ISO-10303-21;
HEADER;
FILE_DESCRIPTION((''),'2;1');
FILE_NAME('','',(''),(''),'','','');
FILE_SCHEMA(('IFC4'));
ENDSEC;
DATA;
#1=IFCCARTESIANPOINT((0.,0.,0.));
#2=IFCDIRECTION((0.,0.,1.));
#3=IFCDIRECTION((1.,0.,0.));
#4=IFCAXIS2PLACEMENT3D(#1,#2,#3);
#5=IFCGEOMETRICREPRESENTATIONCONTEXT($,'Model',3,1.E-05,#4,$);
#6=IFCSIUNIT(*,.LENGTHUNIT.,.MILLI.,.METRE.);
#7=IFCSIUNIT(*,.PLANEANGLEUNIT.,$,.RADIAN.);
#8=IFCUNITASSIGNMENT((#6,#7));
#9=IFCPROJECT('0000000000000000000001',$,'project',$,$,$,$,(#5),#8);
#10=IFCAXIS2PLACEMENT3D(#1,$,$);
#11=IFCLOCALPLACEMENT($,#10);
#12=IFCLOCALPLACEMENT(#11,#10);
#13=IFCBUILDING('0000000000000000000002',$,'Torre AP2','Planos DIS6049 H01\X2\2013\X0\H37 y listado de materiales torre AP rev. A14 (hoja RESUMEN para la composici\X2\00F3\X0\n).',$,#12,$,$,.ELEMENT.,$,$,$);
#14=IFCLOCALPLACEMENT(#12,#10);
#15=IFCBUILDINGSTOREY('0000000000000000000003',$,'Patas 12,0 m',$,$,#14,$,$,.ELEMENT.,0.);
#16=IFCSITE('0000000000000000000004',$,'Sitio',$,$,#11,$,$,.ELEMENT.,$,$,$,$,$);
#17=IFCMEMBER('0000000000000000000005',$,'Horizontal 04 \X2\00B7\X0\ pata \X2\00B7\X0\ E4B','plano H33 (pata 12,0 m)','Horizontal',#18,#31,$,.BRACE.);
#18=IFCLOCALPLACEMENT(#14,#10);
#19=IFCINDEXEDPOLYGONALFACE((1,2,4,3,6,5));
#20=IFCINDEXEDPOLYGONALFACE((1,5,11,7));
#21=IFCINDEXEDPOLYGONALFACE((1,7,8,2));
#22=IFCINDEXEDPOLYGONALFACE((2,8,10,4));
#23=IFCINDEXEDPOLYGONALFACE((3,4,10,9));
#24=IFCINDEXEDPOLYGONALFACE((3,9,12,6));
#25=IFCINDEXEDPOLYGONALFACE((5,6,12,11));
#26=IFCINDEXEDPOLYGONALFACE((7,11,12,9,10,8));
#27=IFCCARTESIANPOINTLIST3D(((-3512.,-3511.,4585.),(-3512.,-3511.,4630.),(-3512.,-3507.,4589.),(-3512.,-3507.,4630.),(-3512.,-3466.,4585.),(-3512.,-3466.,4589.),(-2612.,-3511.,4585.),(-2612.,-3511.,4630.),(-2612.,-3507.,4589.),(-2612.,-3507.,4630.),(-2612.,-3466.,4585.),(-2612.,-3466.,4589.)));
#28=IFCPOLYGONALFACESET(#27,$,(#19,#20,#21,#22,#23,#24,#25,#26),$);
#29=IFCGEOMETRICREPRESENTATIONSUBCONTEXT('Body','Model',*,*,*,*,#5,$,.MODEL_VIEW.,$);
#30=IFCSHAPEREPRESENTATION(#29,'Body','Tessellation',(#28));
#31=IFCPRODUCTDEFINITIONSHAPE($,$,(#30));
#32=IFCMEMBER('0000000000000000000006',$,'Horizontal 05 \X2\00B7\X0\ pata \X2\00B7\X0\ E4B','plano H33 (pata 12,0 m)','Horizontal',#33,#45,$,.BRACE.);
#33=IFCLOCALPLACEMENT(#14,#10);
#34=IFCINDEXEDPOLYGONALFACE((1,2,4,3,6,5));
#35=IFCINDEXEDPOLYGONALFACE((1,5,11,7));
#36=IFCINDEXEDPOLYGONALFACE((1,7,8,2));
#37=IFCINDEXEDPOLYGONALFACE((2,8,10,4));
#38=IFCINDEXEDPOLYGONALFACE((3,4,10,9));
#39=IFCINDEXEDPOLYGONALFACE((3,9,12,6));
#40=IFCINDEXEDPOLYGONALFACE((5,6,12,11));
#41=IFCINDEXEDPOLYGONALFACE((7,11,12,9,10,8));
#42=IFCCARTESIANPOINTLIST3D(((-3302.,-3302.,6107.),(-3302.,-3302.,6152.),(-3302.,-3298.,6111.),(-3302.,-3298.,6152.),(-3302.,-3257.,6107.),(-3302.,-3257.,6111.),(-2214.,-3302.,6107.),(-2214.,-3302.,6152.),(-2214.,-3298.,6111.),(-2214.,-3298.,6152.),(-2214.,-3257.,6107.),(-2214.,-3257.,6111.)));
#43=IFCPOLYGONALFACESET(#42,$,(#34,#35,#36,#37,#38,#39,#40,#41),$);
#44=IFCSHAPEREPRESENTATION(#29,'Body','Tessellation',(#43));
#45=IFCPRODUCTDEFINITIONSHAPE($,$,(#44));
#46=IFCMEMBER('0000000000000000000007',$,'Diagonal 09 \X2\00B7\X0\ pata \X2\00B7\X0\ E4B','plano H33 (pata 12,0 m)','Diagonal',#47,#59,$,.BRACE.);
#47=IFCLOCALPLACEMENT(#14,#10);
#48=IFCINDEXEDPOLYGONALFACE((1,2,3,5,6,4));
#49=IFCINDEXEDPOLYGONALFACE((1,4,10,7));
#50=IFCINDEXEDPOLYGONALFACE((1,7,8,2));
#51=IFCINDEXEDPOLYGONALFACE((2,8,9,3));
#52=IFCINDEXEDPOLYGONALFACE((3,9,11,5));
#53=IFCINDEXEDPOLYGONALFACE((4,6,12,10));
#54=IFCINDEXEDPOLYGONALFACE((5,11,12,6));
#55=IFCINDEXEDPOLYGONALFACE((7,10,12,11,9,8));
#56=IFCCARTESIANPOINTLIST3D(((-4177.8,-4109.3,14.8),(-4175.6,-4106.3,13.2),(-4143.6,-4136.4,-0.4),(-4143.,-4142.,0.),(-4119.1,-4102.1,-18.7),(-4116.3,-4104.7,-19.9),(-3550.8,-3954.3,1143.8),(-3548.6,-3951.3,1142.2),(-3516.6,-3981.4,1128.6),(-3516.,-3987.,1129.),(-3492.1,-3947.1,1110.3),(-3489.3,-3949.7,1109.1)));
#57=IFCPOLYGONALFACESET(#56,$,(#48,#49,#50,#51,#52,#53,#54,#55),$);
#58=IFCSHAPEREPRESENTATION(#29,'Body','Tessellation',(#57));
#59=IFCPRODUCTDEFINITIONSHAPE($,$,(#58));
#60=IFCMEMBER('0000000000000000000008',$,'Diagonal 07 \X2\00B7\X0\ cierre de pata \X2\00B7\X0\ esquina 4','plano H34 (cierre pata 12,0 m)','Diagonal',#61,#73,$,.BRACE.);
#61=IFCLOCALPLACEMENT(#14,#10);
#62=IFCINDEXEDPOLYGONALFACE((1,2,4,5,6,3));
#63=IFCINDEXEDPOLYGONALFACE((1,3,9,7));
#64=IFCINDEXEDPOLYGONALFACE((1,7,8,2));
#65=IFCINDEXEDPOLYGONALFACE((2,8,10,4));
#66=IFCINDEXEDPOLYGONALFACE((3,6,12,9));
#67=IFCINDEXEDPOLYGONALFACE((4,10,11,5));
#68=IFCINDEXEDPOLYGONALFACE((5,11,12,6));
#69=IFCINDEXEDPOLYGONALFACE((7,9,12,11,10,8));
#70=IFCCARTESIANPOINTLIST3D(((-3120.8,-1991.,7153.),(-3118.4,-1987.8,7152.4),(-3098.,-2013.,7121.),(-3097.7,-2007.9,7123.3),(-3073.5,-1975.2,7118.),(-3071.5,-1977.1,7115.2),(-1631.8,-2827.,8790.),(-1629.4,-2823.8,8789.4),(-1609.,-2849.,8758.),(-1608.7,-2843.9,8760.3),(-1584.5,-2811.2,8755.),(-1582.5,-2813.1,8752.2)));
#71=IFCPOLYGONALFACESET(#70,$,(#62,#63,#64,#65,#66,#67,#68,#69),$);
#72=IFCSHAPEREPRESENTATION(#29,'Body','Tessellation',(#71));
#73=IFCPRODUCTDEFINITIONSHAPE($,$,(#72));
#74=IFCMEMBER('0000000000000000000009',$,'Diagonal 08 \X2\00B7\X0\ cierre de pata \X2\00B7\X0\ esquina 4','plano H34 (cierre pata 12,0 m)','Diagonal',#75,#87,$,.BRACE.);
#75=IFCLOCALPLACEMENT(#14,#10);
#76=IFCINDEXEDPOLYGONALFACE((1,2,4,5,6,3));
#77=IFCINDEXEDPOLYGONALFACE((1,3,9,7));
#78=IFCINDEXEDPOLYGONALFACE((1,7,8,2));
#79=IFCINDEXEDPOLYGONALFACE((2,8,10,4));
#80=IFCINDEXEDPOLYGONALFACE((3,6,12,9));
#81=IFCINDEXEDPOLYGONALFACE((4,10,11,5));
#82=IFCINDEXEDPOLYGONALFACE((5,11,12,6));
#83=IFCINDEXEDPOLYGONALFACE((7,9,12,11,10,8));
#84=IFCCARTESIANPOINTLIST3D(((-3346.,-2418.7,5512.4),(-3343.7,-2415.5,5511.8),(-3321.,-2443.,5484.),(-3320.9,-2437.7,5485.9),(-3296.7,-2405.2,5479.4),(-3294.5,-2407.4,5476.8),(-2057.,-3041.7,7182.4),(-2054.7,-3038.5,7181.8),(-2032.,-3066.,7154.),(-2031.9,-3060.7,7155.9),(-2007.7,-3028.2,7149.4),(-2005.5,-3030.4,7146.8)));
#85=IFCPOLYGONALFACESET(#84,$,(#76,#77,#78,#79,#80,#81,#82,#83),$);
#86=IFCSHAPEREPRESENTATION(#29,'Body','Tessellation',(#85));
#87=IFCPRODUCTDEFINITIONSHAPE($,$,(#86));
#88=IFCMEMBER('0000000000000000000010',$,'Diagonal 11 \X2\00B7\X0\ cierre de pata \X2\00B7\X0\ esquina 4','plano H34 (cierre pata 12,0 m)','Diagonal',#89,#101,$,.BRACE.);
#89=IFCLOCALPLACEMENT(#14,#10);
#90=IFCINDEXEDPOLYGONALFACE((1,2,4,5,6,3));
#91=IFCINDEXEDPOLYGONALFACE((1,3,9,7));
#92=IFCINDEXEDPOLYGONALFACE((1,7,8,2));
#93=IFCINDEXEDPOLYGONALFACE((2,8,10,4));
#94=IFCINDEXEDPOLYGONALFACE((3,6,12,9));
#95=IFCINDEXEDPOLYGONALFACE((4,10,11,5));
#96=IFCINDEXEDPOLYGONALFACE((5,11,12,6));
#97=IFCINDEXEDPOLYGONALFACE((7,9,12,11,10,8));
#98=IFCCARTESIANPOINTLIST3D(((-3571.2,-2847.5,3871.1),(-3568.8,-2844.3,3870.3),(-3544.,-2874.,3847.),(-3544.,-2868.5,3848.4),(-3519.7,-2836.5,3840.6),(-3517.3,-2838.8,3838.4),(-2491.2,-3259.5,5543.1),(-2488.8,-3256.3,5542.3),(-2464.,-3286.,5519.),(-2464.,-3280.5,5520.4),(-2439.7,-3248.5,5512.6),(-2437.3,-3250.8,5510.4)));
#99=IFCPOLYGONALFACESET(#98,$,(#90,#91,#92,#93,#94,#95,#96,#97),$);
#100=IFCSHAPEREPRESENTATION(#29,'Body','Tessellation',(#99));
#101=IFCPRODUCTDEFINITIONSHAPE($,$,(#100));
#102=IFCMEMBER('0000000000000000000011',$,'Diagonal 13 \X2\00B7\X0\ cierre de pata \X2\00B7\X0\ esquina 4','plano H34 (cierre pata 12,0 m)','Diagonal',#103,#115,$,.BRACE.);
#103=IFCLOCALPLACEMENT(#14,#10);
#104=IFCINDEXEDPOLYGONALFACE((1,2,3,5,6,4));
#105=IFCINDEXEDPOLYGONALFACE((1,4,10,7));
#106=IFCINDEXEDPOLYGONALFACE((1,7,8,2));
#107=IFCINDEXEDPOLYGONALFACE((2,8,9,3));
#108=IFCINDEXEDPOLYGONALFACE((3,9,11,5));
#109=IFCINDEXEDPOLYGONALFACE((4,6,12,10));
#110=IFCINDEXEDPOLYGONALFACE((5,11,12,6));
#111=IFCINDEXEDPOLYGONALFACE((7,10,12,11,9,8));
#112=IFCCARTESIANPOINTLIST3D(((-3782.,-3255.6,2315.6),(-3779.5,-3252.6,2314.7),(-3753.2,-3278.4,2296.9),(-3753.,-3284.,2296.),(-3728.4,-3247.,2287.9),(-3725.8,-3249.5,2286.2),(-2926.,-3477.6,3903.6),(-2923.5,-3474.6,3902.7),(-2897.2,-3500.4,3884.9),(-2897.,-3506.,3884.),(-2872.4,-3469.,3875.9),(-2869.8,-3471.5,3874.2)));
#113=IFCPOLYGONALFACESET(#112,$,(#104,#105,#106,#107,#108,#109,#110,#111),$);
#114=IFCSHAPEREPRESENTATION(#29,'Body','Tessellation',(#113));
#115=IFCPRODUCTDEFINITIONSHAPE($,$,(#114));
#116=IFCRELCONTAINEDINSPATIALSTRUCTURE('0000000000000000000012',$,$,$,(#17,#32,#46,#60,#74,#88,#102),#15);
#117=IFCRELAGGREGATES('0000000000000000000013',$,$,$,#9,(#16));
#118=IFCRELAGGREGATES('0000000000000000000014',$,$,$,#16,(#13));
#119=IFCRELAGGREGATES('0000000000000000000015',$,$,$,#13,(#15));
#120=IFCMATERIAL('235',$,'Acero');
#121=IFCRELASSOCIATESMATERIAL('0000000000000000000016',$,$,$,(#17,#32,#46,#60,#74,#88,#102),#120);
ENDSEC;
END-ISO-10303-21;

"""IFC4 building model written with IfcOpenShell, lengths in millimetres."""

from ifc_helpers import new_model, si_unit, frame, frame_2d, origin, origin_with_axes, place, context, subcontext, project, spatial, l_section, extrude, material, element, save


model = new_model("IFC4")

# Units and contexts
model_context = context("Model", 3, precision=1e-05, world=origin_with_axes())
body_context = subcontext(model_context, "Body", "Model", "MODEL_VIEW")
ifc_project = project(units=[si_unit("LENGTHUNIT", "METRE", prefix="MILLI"), si_unit("PLANEANGLEUNIT", "RADIAN")], contexts=[model_context])

# Site, building, storey
site_placement = place(None, origin())
site = spatial("IfcSite", under=ifc_project, at=site_placement, Name="Sitio", CompositionType="ELEMENT")
building_placement = place(site_placement, origin())
building = spatial("IfcBuilding", under=site, at=building_placement, Name="Torre AP2", Description="Planos DIS6049 H01–H37 y listado de materiales torre AP rev. A14 (hoja RESUMEN para la composición).", CompositionType="ELEMENT")
storey_placement = place(building_placement, origin())
storey = spatial("IfcBuildingStorey", under=building, at=storey_placement, Name="Patas 12,0 m", CompositionType="ELEMENT", Elevation=0.0)

# Members
ifc_material_1 = material(Name="235", Category="Acero")
member_1_placement = place(storey_placement, frame((-3512.0, -3511.0, 4585.0), z_axis=(1.0, 0.0, 0.0), x_axis=(0.0, 1.0, 0.0)))
element("IfcMember", 1, at=member_1_placement, inside=storey, material=ifc_material_1, Name="Horizontal 04 · pata · E4B", Description="plano H33 (pata 12,0 m)", ObjectType="Horizontal", PredefinedType="BRACE", context=body_context, shape_type="SweptSolid", body=[
    extrude(l_section(Depth=45.0, Width=45.0, Thickness=4.0, at=frame_2d((22.5, 22.5))), None, (0.0, 0.0, 1.0), 900.0),
])
member_2_placement = place(storey_placement, frame((-3302.0, -3302.0, 6107.0), z_axis=(1.0, 0.0, 0.0), x_axis=(0.0, 1.0, 0.0)))
element("IfcMember", 2, at=member_2_placement, inside=storey, material=ifc_material_1, Name="Horizontal 05 · pata · E4B", Description="plano H33 (pata 12,0 m)", ObjectType="Horizontal", PredefinedType="BRACE", context=body_context, shape_type="SweptSolid", body=[
    extrude(l_section(Depth=45.0, Width=45.0, Thickness=4.0, at=frame_2d((22.5, 22.5))), None, (0.0, 0.0, 1.0), 1088.0),
])
member_3_placement = place(storey_placement, frame((-4143.0, -4142.0, 0.0), z_axis=(0.482052, 0.119168, 0.868001), x_axis=(0.53324, 0.746182, -0.398583)))
element("IfcMember", 3, at=member_3_placement, inside=storey, material=ifc_material_1, Name="Diagonal 09 · pata · E4B", Description="plano H33 (pata 12,0 m)", ObjectType="Diagonal", PredefinedType="BRACE", context=body_context, shape_type="SweptSolid", body=[
    extrude(l_section(Depth=50.0, Width=50.0, Thickness=4.0, at=frame_2d((25.0, 25.0))), None, (0.0, 0.0, 1.0), 1300.7),
])
member_4_placement = place(storey_placement, frame((-3098.0, -2013.0, 7121.0), z_axis=(0.629454, -0.353407, 0.692019), x_axis=(0.589858, 0.797058, -0.12948)))
element("IfcMember", 4, at=member_4_placement, inside=storey, material=ifc_material_1, Name="Diagonal 07 · cierre de pata · esquina 4", Description="plano H34 (cierre pata 12,0 m)", ObjectType="Diagonal", PredefinedType="BRACE", context=body_context, shape_type="SweptSolid", body=[
    extrude(l_section(Depth=45.0, Width=45.0, Thickness=4.0, at=frame_2d((22.5, 22.5))), None, (0.0, 0.0, 1.0), 2365.5),
])
member_5_placement = place(storey_placement, frame((-3321.0, -2443.0, 5484.0), z_axis=(0.585997, -0.283224, 0.759205), x_axis=(0.58915, 0.792183, -0.159212)))
element("IfcMember", 5, at=member_5_placement, inside=storey, material=ifc_material_1, Name="Diagonal 08 · cierre de pata · esquina 4", Description="plano H34 (cierre pata 12,0 m)", ObjectType="Diagonal", PredefinedType="BRACE", context=body_context, shape_type="SweptSolid", body=[
    extrude(l_section(Depth=45.0, Width=45.0, Thickness=4.0, at=frame_2d((22.5, 22.5))), None, (0.0, 0.0, 1.0), 2199.7),
])
member_6_placement = place(storey_placement, frame((-3544.0, -2874.0, 3847.0), z_axis=(0.531322, -0.20269, 0.822565), x_axis=(0.593545, 0.781874, -0.190728)))
element("IfcMember", 6, at=member_6_placement, inside=storey, material=ifc_material_1, Name="Diagonal 11 · cierre de pata · esquina 4", Description="plano H34 (cierre pata 12,0 m)", ObjectType="Diagonal", PredefinedType="BRACE", context=body_context, shape_type="SweptSolid", body=[
    extrude(l_section(Depth=45.0, Width=45.0, Thickness=4.0, at=frame_2d((22.5, 22.5))), None, (0.0, 0.0, 1.0), 2032.7),
])
member_7_placement = place(storey_placement, frame((-3753.0, -3284.0, 2296.0), z_axis=(0.470944, -0.122137, 0.873667), x_axis=(0.603592, 0.766867, -0.218155)))
element("IfcMember", 7, at=member_7_placement, inside=storey, material=ifc_material_1, Name="Diagonal 13 · cierre de pata · esquina 4", Description="plano H34 (cierre pata 12,0 m)", ObjectType="Diagonal", PredefinedType="BRACE", context=body_context, shape_type="SweptSolid", body=[
    extrude(l_section(Depth=45.0, Width=45.0, Thickness=4.0, at=frame_2d((22.5, 22.5))), None, (0.0, 0.0, 1.0), 1817.6),
])

save(model, "model.ifc")
